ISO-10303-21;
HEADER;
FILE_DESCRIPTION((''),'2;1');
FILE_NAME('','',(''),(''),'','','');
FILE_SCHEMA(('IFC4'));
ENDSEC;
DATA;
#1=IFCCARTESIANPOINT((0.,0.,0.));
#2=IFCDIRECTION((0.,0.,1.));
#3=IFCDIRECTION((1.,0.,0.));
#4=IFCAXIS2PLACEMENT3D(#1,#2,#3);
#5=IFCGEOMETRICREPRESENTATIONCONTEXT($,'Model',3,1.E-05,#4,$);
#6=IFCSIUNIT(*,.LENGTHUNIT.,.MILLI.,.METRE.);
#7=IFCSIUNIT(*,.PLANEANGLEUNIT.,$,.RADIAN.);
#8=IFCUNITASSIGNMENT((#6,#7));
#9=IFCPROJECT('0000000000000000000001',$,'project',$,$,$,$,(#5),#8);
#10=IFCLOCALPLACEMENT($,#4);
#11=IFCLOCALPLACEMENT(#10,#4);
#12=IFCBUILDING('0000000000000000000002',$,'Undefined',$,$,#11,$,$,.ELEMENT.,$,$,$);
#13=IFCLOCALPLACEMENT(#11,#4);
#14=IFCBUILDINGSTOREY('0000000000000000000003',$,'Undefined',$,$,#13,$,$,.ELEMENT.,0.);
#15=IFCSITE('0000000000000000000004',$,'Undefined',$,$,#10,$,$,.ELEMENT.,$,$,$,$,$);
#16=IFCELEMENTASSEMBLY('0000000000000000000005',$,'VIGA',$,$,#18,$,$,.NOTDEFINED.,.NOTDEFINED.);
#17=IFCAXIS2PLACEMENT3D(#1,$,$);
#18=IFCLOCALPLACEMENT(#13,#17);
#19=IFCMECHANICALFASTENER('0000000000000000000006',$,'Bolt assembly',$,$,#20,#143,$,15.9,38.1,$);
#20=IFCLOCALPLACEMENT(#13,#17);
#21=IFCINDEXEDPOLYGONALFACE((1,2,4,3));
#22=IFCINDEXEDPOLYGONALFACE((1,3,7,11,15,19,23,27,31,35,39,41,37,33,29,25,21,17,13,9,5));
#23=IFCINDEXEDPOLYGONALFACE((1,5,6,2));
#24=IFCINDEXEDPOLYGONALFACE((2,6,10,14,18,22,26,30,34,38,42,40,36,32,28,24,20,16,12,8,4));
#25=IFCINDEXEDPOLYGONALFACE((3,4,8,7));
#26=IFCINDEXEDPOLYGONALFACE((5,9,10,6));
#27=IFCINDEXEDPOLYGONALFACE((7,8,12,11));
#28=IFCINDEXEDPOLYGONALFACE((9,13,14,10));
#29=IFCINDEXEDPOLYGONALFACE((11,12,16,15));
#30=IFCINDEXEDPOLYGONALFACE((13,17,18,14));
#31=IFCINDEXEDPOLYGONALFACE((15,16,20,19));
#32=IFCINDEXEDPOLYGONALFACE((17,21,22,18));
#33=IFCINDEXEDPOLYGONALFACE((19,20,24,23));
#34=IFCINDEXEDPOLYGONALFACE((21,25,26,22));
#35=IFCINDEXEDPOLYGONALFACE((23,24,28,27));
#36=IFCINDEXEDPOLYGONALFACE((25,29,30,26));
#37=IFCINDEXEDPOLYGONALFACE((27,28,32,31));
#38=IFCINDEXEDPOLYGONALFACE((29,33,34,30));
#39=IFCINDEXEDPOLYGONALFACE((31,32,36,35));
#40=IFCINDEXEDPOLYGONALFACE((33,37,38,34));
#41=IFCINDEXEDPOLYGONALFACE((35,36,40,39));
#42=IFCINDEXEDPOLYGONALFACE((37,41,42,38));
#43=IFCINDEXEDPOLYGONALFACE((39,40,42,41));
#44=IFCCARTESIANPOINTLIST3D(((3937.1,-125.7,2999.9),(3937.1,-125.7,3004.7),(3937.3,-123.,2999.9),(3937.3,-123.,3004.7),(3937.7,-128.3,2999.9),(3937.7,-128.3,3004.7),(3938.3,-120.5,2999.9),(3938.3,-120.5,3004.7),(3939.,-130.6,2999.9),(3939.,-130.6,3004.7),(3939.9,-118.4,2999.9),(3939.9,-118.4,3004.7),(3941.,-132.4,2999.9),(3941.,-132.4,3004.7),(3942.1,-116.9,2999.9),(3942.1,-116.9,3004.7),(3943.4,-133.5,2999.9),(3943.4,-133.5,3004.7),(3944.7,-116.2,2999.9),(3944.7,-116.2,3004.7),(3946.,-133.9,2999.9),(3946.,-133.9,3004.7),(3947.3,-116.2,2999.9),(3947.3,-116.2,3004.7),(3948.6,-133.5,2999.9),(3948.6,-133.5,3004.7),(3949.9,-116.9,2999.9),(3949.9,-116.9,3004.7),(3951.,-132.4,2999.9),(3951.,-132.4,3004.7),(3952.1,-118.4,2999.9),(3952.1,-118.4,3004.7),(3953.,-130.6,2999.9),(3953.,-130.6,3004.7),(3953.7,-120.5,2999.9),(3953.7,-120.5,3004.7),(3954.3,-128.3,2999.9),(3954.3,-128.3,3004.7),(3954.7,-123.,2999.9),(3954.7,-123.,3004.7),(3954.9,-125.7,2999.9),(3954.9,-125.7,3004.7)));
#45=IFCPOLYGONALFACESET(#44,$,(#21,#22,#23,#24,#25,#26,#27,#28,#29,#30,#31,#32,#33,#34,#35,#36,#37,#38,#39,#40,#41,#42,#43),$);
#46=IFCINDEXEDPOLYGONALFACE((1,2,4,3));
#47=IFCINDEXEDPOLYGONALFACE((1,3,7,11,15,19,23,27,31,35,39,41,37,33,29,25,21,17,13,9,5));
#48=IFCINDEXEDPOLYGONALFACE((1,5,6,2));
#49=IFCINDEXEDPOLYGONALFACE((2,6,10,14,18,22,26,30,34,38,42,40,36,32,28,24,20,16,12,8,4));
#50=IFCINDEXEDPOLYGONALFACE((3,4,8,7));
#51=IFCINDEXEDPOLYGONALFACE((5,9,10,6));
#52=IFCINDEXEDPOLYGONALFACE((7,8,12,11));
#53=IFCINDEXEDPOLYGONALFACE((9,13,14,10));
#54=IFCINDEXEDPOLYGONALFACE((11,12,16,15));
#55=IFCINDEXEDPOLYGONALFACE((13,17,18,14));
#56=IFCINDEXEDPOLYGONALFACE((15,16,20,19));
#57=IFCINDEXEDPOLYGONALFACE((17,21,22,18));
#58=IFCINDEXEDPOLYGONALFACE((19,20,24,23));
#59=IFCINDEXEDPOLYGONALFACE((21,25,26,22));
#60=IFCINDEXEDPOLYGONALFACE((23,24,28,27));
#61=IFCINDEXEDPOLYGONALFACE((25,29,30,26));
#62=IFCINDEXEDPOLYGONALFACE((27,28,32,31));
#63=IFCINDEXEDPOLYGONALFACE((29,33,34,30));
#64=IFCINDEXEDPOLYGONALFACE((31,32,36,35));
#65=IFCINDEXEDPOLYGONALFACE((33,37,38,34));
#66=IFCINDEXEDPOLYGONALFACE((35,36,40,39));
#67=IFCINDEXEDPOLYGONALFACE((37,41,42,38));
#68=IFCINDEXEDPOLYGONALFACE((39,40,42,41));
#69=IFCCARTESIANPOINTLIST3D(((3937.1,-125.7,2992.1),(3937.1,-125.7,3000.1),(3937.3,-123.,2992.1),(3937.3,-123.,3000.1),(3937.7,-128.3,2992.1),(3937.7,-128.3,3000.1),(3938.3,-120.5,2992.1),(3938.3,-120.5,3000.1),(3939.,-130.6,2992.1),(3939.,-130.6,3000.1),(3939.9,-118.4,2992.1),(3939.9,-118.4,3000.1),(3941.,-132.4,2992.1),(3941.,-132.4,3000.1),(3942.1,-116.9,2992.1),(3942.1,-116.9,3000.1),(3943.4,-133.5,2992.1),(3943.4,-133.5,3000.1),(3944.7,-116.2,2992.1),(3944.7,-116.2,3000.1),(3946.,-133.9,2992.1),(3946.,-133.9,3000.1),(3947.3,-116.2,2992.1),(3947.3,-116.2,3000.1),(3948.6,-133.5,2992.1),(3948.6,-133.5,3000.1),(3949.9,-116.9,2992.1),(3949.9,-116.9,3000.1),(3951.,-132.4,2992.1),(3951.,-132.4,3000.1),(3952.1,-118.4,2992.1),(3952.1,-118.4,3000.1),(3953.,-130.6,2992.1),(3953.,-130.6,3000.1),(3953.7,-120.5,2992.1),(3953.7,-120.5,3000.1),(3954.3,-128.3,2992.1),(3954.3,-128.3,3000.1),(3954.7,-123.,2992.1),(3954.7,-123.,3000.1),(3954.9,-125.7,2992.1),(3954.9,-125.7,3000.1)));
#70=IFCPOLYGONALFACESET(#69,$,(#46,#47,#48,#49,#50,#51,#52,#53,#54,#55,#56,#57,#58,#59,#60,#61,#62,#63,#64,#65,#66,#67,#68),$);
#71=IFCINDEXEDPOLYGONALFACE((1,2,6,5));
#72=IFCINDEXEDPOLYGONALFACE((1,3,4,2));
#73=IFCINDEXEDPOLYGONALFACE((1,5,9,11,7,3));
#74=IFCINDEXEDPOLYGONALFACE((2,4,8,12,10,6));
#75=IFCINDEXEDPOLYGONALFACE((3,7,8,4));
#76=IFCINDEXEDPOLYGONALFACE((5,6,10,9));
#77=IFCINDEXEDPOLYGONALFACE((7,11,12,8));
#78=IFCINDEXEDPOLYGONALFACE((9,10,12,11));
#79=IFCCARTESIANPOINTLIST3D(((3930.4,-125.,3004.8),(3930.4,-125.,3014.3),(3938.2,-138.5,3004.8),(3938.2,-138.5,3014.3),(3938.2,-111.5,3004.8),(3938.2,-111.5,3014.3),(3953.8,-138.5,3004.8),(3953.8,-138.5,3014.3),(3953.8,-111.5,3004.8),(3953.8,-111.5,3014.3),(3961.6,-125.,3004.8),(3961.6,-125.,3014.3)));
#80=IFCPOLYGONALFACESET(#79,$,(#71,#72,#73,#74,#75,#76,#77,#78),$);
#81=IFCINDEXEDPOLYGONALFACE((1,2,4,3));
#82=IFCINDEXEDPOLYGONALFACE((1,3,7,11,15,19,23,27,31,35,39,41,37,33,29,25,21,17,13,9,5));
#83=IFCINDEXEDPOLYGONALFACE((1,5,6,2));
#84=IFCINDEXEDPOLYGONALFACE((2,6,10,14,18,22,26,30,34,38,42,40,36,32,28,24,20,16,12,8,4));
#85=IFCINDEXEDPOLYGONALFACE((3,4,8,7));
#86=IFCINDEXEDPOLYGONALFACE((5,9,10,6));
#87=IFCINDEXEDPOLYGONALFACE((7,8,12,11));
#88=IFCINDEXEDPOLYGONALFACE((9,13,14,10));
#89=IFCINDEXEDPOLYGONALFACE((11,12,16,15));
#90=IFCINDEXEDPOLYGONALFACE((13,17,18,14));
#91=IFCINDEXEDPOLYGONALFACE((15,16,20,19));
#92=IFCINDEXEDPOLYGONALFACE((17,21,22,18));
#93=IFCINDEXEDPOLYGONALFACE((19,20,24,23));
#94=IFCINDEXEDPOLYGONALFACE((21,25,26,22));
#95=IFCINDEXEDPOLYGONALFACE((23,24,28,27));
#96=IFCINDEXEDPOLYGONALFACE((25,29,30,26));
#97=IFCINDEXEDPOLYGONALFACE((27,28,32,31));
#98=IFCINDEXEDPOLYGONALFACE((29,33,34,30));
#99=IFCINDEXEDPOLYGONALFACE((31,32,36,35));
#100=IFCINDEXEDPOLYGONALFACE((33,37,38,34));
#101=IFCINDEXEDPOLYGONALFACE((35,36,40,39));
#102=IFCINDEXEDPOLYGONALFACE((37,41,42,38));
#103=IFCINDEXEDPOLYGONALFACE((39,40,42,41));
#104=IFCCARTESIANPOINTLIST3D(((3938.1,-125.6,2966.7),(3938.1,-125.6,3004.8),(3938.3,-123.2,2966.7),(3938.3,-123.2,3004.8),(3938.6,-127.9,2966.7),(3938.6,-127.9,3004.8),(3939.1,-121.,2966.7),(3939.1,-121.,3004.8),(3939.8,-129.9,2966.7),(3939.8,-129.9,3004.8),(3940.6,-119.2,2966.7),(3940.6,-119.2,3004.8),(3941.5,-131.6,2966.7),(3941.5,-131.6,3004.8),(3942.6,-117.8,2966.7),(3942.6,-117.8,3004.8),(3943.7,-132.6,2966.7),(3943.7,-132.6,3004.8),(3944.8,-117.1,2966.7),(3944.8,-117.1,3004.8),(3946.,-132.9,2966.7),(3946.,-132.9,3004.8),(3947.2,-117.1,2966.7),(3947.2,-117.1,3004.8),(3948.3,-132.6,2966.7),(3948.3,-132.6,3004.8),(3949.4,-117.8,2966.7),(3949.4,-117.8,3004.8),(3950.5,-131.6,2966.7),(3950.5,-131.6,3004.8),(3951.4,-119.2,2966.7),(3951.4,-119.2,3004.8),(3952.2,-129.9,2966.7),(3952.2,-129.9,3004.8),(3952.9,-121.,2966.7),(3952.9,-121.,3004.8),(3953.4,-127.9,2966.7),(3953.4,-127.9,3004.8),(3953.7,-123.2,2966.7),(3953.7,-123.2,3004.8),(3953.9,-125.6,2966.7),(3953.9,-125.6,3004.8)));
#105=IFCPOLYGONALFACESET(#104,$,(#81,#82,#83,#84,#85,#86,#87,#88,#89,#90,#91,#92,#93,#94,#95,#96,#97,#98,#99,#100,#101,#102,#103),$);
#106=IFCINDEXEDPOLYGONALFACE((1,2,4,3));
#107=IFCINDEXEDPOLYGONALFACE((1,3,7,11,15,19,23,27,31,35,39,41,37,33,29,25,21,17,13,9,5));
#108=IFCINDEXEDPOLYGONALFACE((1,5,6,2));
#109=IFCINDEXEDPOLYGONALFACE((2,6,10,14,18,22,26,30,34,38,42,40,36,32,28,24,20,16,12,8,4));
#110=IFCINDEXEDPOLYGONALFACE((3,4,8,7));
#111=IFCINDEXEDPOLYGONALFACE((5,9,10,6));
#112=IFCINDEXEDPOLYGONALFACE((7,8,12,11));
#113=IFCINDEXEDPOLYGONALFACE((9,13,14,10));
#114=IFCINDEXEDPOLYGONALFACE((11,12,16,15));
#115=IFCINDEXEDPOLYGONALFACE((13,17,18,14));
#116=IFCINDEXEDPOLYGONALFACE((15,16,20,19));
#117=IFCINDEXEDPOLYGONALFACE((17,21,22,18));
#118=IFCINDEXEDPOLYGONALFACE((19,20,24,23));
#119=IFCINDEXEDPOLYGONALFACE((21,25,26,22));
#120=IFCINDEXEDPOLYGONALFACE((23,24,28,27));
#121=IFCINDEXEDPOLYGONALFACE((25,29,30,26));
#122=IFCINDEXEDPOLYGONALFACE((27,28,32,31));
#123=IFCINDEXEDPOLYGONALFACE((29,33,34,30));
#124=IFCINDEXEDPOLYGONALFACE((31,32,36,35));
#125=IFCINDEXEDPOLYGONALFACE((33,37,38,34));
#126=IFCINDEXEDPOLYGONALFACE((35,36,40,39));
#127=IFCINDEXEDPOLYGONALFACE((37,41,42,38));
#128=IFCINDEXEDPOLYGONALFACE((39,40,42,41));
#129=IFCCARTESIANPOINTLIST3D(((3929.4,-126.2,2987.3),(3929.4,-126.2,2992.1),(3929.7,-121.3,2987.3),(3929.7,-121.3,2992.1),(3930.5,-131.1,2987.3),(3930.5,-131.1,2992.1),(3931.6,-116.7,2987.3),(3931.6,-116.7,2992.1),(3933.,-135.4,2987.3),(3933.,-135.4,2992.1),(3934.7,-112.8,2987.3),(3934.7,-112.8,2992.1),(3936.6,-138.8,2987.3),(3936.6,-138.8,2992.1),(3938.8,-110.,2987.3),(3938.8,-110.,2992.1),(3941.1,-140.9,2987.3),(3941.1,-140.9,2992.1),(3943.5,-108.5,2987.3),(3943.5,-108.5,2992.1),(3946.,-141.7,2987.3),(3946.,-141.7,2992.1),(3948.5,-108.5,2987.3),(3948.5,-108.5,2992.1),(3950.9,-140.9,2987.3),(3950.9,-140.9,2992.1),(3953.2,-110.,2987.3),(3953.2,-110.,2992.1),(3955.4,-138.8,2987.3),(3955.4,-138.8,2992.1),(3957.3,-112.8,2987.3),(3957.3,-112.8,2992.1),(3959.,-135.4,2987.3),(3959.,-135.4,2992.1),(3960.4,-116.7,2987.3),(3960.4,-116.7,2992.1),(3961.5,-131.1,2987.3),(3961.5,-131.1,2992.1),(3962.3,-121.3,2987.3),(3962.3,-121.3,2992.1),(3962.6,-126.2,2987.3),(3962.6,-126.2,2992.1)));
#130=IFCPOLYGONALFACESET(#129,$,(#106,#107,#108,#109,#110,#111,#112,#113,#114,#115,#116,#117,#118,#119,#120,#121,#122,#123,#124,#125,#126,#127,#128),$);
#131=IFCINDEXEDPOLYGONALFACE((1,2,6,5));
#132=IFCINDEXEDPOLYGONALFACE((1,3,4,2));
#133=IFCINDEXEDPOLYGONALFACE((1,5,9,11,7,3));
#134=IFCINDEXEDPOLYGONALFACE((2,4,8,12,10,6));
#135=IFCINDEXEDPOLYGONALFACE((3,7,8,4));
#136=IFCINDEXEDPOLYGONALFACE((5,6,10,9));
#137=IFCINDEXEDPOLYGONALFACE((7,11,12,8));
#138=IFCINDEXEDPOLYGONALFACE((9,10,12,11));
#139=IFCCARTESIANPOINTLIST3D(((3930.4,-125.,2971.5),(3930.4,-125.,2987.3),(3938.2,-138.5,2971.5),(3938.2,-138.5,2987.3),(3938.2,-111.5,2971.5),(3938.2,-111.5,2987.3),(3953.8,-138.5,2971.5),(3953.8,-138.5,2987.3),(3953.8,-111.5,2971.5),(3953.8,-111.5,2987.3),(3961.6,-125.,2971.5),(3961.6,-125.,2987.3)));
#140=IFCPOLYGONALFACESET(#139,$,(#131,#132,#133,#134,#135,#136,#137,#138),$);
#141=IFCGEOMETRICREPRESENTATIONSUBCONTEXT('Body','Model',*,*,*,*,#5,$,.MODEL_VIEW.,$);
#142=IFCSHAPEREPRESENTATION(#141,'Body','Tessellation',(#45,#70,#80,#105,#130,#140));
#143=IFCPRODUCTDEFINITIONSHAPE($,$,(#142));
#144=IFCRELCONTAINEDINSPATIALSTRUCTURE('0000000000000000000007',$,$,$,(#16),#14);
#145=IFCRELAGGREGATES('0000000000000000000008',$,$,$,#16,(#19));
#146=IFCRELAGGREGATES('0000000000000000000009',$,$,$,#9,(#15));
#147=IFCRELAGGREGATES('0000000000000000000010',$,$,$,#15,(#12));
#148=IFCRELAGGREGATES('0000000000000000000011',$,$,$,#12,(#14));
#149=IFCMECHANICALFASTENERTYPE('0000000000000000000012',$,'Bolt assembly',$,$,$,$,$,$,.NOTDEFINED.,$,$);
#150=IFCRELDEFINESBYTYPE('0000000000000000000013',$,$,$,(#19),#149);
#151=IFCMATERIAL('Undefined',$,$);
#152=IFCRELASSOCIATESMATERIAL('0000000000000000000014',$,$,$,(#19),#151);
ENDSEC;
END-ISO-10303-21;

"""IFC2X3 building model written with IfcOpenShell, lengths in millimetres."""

from ifc_helpers import new_model, si_unit, frame, origin_with_axes, origin_2d_with_axis, place, context, subcontext, project, spatial, polyline, circle, outline, extrude, source, transform, mapped, material, type_object, element, aggregate, save


model = new_model("IFC2X3")

# Units and contexts
model_context = context("Model", 3, precision=1e-05, world=origin_with_axes())
body_context = subcontext(model_context, "Body", "Model", "MODEL_VIEW")
ifc_project = project(units=[si_unit("LENGTHUNIT", "METRE", prefix="MILLI"), si_unit("PLANEANGLEUNIT", "RADIAN")], contexts=[model_context])

# Site, building, storey
site_placement = place(None, origin_with_axes())
site = spatial("IfcSite", under=ifc_project, at=site_placement, Name="Undefined", CompositionType="ELEMENT")
building_placement = place(site_placement, origin_with_axes())
building = spatial("IfcBuilding", under=site, at=building_placement, Name="Undefined", CompositionType="ELEMENT")
storey_placement = place(building_placement, origin_with_axes())
storey = spatial("IfcBuildingStorey", under=building, at=storey_placement, Name="Undefined", CompositionType="ELEMENT", Elevation=0.0)

# Element assembly
assembly_1_placement = place(storey_placement, origin_with_axes())
assembly_1 = element("IfcElementAssembly", 1, at=assembly_1_placement, inside=storey, Name="VIGA", AssemblyPlace="NOTDEFINED", PredefinedType="NOTDEFINED")

# Mechanical fastener
ifc_material_1 = material(Name="Undefined")
mechanical_fastener_type = type_object("IfcMechanicalFastenerType", Name="Bolt assembly")
shared_shape_1 = source(origin_with_axes(), body_context, "Body", "SweptSolid", [
    extrude(circle(Radius=8.9, at=origin_2d_with_axis()), frame((0.0, -4.7, 0.0), z_axis=(0.0, 1.0, 0.0), x_axis=(1.0, 0.0, 0.0)), (0.0, 0.0, 1.0), 4.8),
    extrude(circle(Radius=8.9, at=origin_2d_with_axis()), frame((0.0, -0.1, 0.0), z_axis=(0.0, 1.0, 0.0), x_axis=(1.0, 0.0, 0.0)), (0.0, 0.0, 1.0), 8.0),
    extrude(outline(polyline([(13.5, -7.8), (13.5, 7.8), (0.0, 15.6), (-13.5, 7.8), (-13.5, -7.8), (0.0, -15.6), (13.5, -7.8)])), frame((0.0, -14.3, 0.0), z_axis=(0.0, 1.0, 0.0), x_axis=(1.0, 0.0, 0.0)), (0.0, 0.0, 1.0), 9.5),
    extrude(circle(Radius=7.9, at=origin_2d_with_axis()), frame((0.0, -4.8, 0.0), z_axis=(0.0, 1.0, 0.0), x_axis=(1.0, 0.0, 0.0)), (0.0, 0.0, 1.0), 38.1),
    extrude(circle(Radius=16.7, at=origin_2d_with_axis()), frame((0.0, 7.9, 0.0), z_axis=(0.0, 1.0, 0.0), x_axis=(1.0, 0.0, 0.0)), (0.0, 0.0, 1.0), 4.8),
    extrude(outline(polyline([(13.5, -7.8), (13.5, 7.8), (0.0, 15.6), (-13.5, 7.8), (-13.5, -7.8), (0.0, -15.6), (13.5, -7.8)])), frame((0.0, 12.7, 0.0), z_axis=(0.0, 1.0, 0.0), x_axis=(1.0, 0.0, 0.0)), (0.0, 0.0, 1.0), 15.9),
])
mechanical_fastener_1_placement = place(assembly_1_placement, frame((3946.0, -125.0, 3000.0), z_axis=(1.0, -0.000001, 0.0), x_axis=(-0.000001, -1.0, 0.0)))
mechanical_fastener_1 = element("IfcMechanicalFastener", 2, at=mechanical_fastener_1_placement, type_object=mechanical_fastener_type, material=ifc_material_1, Name="Bolt assembly", NominalDiameter=15.9, NominalLength=38.1, context=body_context, shape_type="MappedRepresentation", body=[
    mapped(shared_shape_1, transform((0.0, 0.0, 0.0))),
])
aggregate(assembly_1, [mechanical_fastener_1])

save(model, "model.ifc")
